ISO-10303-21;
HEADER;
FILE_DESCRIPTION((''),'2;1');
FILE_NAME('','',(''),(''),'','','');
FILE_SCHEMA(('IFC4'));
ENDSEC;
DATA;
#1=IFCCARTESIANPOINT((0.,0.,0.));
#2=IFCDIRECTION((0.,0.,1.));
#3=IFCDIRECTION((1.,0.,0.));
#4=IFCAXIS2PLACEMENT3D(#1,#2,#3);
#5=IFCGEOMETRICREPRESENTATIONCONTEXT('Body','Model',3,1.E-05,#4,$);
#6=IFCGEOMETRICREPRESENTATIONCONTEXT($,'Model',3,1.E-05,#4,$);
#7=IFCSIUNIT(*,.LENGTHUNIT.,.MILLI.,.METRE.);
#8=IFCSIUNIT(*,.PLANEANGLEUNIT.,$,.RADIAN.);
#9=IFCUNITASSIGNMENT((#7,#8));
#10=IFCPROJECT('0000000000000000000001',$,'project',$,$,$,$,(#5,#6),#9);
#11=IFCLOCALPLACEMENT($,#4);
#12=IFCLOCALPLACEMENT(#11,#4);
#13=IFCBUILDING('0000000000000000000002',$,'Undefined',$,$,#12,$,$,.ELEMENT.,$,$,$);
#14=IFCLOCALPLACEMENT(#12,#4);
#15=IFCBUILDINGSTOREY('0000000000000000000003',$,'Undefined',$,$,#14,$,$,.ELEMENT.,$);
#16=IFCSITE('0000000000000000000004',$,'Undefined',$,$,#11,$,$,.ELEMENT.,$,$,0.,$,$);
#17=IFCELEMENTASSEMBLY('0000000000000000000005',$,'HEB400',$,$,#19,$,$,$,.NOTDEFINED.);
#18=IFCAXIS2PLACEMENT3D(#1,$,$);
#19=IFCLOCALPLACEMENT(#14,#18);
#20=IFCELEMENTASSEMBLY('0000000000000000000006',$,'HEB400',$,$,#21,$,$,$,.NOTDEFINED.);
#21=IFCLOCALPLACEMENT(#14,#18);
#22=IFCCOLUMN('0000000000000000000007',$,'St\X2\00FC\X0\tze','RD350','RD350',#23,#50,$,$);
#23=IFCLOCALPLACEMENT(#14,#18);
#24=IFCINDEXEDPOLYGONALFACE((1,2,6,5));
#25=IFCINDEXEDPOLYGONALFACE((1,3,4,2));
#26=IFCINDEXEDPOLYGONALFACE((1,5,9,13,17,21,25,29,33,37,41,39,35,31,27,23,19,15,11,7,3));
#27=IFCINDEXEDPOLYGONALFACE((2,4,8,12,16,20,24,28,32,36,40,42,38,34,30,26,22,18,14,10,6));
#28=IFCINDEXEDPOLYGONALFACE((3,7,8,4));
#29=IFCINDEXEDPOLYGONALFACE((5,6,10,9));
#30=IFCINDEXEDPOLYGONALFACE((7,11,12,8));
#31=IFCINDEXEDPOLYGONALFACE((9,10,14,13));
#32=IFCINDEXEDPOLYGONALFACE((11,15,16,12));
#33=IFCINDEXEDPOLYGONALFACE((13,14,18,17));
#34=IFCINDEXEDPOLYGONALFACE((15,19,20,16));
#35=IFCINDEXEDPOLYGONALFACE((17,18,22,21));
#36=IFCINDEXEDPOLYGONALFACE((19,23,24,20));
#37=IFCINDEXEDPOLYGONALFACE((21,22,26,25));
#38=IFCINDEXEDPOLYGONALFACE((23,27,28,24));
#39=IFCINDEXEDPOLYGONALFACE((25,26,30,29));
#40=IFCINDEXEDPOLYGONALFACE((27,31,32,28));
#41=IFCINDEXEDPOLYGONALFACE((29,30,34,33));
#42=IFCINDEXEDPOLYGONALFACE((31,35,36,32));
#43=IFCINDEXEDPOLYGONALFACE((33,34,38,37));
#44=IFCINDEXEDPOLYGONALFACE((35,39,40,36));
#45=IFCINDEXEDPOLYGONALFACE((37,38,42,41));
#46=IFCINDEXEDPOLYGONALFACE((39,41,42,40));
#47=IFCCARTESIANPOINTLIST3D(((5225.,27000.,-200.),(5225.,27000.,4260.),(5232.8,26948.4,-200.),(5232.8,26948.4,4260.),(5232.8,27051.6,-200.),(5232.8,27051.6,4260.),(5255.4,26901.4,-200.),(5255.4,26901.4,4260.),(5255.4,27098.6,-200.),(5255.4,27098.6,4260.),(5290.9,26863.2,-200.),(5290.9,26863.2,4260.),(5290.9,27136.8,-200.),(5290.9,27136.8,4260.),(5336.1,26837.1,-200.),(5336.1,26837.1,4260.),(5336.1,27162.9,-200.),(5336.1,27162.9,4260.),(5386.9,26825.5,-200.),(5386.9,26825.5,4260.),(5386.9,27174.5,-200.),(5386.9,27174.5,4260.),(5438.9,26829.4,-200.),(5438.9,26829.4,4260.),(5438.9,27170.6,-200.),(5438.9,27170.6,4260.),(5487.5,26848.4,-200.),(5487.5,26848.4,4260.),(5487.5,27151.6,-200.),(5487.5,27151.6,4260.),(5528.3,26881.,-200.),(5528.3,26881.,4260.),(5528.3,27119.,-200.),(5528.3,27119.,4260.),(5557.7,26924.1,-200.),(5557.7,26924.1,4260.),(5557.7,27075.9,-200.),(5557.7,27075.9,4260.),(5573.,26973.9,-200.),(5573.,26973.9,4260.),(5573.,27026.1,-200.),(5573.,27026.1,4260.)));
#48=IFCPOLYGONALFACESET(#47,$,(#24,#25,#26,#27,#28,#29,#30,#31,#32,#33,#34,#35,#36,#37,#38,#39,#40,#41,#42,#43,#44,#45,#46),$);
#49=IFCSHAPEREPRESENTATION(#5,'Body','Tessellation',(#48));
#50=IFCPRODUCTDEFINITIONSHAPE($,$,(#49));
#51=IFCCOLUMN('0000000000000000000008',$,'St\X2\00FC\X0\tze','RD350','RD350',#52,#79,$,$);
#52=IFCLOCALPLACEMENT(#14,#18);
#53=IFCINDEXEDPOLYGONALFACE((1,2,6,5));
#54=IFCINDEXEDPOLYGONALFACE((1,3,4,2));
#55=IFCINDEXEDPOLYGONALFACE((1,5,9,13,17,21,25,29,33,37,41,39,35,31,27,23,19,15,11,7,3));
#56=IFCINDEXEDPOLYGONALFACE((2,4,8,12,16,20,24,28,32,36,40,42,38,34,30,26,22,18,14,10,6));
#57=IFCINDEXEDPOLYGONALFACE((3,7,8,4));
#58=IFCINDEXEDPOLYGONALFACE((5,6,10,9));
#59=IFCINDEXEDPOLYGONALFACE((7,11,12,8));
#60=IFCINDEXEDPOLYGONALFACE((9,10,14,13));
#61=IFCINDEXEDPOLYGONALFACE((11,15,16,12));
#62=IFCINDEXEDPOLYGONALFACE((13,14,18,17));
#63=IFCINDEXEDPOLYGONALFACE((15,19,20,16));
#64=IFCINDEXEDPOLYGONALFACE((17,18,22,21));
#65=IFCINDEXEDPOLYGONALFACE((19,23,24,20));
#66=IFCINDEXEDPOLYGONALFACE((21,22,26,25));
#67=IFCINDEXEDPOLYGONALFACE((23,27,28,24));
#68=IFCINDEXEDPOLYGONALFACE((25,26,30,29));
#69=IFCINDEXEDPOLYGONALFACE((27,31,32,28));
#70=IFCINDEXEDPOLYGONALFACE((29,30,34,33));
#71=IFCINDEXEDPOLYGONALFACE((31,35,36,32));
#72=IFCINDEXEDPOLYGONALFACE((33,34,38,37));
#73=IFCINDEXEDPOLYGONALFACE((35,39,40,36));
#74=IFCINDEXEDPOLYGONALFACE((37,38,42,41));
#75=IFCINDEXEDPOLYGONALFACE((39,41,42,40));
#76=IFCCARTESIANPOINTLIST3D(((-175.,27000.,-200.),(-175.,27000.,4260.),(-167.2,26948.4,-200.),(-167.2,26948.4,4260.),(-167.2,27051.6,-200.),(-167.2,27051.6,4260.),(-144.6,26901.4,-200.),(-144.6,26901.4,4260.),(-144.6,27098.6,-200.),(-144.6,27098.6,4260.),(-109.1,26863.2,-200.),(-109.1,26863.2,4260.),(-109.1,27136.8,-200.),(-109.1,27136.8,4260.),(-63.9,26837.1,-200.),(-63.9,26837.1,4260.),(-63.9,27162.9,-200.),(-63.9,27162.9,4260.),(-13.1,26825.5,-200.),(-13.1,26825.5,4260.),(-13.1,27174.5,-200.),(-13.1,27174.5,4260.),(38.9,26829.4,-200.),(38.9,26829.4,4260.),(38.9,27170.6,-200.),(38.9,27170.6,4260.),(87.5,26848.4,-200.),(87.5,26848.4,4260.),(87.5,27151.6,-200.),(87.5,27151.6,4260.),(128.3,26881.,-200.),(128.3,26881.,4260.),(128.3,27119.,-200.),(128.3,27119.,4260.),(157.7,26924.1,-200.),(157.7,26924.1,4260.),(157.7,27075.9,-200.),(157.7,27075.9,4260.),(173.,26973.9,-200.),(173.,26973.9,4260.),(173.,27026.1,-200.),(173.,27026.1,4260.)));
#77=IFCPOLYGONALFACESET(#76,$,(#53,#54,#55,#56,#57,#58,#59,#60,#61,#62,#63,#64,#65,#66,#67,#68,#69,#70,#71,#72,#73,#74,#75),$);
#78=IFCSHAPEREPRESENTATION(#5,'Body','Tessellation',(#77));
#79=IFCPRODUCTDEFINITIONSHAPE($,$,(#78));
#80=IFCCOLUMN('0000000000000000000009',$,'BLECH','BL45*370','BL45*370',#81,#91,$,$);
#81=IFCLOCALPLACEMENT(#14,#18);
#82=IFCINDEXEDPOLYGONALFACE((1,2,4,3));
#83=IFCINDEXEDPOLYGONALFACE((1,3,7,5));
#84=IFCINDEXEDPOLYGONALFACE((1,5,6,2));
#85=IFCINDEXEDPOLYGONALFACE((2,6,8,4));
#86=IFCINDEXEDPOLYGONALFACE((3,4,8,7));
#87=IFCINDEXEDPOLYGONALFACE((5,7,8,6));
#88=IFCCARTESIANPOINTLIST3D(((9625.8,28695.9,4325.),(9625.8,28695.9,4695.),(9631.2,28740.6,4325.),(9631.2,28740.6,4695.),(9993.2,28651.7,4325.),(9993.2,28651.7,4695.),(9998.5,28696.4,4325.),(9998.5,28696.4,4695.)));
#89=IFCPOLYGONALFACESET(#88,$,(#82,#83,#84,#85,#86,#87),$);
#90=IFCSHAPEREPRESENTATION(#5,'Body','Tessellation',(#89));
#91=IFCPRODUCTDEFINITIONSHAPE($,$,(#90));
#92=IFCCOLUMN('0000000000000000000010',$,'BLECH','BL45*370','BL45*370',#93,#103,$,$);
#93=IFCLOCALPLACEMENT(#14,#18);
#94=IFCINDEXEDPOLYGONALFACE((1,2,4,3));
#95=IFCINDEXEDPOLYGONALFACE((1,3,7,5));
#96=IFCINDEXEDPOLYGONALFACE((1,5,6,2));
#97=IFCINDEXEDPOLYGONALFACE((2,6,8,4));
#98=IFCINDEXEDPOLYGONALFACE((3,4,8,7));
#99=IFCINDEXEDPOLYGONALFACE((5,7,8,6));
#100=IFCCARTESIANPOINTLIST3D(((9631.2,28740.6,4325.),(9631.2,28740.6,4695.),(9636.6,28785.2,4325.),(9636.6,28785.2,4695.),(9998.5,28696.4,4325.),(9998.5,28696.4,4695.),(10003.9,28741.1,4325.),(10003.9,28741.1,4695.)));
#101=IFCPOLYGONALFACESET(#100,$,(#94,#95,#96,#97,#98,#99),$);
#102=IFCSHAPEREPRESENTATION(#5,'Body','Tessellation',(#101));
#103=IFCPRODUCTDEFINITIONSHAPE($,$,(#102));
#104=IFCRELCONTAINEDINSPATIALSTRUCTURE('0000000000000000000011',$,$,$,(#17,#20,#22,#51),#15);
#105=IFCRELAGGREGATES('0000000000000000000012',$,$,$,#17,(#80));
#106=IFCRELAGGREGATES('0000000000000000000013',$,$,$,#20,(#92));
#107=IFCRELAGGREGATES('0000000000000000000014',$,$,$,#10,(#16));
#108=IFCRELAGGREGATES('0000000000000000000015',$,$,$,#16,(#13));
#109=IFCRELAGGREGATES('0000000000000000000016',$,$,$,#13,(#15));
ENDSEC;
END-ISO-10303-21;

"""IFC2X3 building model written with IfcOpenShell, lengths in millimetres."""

from ifc_helpers import new_model, si_unit, frame, origin_with_axes, origin_2d_with_axis, place, context, project, spatial, rectangle, circle, extrude, element, aggregate, save


model = new_model("IFC2X3")

# Units and contexts
model_context_1 = context("Model", 3, precision=1e-05, world=origin_with_axes(), identifier="Body")
model_context_2 = context("Model", 3, precision=1e-05, world=origin_with_axes())
ifc_project = project(units=[si_unit("LENGTHUNIT", "METRE", prefix="MILLI"), si_unit("PLANEANGLEUNIT", "RADIAN")], contexts=[model_context_1, model_context_2])

# Site, building, storey
site_placement = place(None, origin_with_axes())
site = spatial("IfcSite", under=ifc_project, at=site_placement, Name="Undefined", CompositionType="ELEMENT", RefElevation=0.0)
building_placement = place(site_placement, origin_with_axes())
building = spatial("IfcBuilding", under=site, at=building_placement, Name="Undefined", CompositionType="ELEMENT")
storey_placement = place(building_placement, origin_with_axes())
storey = spatial("IfcBuildingStorey", under=building, at=storey_placement, Name="Undefined", CompositionType="ELEMENT")

# Element assembly
assembly_1 = element("IfcElementAssembly", 1, inside=storey, Name="HEB400", PredefinedType="NOTDEFINED")

# Element assembly
assembly_2 = element("IfcElementAssembly", 2, inside=storey, Name="HEB400", PredefinedType="NOTDEFINED")

# Columns
for number, where, z_axis, x_axis, name in (
    (3, (5400.0, 27000.0, -200.0), (0.0, 0.0, 1.0), (1.0, 0.0, 0.0), "Stütze"),
    (4, (0.0, 27000.0, -200.0), (0.0, 0.0, 1.0), (1.0, 0.0, 0.0), "Stütze"),
):
    element("IfcColumn", number, at=place(storey_placement, frame(where, z_axis=z_axis, x_axis=x_axis)), inside=storey, Name=name, Description="RD350", ObjectType="RD350", context=model_context_1, shape_type="SweptSolid", body=[
        extrude(circle(Radius=175.0, at=origin_2d_with_axis()), frame((0.0, 0.0, 4460.0), z_axis=(0.0, 0.0, -1.0), x_axis=(-1.0, 0.0, 0.0)), (0.0, 0.0, 1.0), 4460.0),
    ])

# Columns
column_1_placement = place(storey_placement, frame((9812.2, 28696.1, 4325.0), z_axis=(0.0, 0.0, 1.0), x_axis=(1.0, 0.0, 0.0)))
column_1 = element("IfcColumn", 5, at=column_1_placement, Name="BLECH", Description="BL45*370", ObjectType="BL45*370", context=model_context_1, shape_type="SweptSolid", body=[
    extrude(rectangle(XDim=45.0, YDim=370.0, at=origin_2d_with_axis()), frame((0.0, 0.0, 370.0), z_axis=(0.0, 0.0, -1.0), x_axis=(0.119373, 0.992849, 0.0)), (0.0, 0.0, 1.0), 370.0),
])
aggregate(assembly_1, [column_1])
column_2_placement = place(storey_placement, frame((9817.6, 28740.8, 4325.0), z_axis=(0.0, 0.0, 1.0), x_axis=(1.0, 0.0, 0.0)))
column_2 = element("IfcColumn", 6, at=column_2_placement, Name="BLECH", Description="BL45*370", ObjectType="BL45*370", context=model_context_1, shape_type="SweptSolid", body=[
    extrude(rectangle(XDim=45.0, YDim=370.0, at=origin_2d_with_axis()), frame((0.0, 0.0, 370.0), z_axis=(0.0, 0.0, -1.0), x_axis=(0.119373, 0.992849, 0.0)), (0.0, 0.0, 1.0), 370.0),
])
aggregate(assembly_2, [column_2])

save(model, "model.ifc")
